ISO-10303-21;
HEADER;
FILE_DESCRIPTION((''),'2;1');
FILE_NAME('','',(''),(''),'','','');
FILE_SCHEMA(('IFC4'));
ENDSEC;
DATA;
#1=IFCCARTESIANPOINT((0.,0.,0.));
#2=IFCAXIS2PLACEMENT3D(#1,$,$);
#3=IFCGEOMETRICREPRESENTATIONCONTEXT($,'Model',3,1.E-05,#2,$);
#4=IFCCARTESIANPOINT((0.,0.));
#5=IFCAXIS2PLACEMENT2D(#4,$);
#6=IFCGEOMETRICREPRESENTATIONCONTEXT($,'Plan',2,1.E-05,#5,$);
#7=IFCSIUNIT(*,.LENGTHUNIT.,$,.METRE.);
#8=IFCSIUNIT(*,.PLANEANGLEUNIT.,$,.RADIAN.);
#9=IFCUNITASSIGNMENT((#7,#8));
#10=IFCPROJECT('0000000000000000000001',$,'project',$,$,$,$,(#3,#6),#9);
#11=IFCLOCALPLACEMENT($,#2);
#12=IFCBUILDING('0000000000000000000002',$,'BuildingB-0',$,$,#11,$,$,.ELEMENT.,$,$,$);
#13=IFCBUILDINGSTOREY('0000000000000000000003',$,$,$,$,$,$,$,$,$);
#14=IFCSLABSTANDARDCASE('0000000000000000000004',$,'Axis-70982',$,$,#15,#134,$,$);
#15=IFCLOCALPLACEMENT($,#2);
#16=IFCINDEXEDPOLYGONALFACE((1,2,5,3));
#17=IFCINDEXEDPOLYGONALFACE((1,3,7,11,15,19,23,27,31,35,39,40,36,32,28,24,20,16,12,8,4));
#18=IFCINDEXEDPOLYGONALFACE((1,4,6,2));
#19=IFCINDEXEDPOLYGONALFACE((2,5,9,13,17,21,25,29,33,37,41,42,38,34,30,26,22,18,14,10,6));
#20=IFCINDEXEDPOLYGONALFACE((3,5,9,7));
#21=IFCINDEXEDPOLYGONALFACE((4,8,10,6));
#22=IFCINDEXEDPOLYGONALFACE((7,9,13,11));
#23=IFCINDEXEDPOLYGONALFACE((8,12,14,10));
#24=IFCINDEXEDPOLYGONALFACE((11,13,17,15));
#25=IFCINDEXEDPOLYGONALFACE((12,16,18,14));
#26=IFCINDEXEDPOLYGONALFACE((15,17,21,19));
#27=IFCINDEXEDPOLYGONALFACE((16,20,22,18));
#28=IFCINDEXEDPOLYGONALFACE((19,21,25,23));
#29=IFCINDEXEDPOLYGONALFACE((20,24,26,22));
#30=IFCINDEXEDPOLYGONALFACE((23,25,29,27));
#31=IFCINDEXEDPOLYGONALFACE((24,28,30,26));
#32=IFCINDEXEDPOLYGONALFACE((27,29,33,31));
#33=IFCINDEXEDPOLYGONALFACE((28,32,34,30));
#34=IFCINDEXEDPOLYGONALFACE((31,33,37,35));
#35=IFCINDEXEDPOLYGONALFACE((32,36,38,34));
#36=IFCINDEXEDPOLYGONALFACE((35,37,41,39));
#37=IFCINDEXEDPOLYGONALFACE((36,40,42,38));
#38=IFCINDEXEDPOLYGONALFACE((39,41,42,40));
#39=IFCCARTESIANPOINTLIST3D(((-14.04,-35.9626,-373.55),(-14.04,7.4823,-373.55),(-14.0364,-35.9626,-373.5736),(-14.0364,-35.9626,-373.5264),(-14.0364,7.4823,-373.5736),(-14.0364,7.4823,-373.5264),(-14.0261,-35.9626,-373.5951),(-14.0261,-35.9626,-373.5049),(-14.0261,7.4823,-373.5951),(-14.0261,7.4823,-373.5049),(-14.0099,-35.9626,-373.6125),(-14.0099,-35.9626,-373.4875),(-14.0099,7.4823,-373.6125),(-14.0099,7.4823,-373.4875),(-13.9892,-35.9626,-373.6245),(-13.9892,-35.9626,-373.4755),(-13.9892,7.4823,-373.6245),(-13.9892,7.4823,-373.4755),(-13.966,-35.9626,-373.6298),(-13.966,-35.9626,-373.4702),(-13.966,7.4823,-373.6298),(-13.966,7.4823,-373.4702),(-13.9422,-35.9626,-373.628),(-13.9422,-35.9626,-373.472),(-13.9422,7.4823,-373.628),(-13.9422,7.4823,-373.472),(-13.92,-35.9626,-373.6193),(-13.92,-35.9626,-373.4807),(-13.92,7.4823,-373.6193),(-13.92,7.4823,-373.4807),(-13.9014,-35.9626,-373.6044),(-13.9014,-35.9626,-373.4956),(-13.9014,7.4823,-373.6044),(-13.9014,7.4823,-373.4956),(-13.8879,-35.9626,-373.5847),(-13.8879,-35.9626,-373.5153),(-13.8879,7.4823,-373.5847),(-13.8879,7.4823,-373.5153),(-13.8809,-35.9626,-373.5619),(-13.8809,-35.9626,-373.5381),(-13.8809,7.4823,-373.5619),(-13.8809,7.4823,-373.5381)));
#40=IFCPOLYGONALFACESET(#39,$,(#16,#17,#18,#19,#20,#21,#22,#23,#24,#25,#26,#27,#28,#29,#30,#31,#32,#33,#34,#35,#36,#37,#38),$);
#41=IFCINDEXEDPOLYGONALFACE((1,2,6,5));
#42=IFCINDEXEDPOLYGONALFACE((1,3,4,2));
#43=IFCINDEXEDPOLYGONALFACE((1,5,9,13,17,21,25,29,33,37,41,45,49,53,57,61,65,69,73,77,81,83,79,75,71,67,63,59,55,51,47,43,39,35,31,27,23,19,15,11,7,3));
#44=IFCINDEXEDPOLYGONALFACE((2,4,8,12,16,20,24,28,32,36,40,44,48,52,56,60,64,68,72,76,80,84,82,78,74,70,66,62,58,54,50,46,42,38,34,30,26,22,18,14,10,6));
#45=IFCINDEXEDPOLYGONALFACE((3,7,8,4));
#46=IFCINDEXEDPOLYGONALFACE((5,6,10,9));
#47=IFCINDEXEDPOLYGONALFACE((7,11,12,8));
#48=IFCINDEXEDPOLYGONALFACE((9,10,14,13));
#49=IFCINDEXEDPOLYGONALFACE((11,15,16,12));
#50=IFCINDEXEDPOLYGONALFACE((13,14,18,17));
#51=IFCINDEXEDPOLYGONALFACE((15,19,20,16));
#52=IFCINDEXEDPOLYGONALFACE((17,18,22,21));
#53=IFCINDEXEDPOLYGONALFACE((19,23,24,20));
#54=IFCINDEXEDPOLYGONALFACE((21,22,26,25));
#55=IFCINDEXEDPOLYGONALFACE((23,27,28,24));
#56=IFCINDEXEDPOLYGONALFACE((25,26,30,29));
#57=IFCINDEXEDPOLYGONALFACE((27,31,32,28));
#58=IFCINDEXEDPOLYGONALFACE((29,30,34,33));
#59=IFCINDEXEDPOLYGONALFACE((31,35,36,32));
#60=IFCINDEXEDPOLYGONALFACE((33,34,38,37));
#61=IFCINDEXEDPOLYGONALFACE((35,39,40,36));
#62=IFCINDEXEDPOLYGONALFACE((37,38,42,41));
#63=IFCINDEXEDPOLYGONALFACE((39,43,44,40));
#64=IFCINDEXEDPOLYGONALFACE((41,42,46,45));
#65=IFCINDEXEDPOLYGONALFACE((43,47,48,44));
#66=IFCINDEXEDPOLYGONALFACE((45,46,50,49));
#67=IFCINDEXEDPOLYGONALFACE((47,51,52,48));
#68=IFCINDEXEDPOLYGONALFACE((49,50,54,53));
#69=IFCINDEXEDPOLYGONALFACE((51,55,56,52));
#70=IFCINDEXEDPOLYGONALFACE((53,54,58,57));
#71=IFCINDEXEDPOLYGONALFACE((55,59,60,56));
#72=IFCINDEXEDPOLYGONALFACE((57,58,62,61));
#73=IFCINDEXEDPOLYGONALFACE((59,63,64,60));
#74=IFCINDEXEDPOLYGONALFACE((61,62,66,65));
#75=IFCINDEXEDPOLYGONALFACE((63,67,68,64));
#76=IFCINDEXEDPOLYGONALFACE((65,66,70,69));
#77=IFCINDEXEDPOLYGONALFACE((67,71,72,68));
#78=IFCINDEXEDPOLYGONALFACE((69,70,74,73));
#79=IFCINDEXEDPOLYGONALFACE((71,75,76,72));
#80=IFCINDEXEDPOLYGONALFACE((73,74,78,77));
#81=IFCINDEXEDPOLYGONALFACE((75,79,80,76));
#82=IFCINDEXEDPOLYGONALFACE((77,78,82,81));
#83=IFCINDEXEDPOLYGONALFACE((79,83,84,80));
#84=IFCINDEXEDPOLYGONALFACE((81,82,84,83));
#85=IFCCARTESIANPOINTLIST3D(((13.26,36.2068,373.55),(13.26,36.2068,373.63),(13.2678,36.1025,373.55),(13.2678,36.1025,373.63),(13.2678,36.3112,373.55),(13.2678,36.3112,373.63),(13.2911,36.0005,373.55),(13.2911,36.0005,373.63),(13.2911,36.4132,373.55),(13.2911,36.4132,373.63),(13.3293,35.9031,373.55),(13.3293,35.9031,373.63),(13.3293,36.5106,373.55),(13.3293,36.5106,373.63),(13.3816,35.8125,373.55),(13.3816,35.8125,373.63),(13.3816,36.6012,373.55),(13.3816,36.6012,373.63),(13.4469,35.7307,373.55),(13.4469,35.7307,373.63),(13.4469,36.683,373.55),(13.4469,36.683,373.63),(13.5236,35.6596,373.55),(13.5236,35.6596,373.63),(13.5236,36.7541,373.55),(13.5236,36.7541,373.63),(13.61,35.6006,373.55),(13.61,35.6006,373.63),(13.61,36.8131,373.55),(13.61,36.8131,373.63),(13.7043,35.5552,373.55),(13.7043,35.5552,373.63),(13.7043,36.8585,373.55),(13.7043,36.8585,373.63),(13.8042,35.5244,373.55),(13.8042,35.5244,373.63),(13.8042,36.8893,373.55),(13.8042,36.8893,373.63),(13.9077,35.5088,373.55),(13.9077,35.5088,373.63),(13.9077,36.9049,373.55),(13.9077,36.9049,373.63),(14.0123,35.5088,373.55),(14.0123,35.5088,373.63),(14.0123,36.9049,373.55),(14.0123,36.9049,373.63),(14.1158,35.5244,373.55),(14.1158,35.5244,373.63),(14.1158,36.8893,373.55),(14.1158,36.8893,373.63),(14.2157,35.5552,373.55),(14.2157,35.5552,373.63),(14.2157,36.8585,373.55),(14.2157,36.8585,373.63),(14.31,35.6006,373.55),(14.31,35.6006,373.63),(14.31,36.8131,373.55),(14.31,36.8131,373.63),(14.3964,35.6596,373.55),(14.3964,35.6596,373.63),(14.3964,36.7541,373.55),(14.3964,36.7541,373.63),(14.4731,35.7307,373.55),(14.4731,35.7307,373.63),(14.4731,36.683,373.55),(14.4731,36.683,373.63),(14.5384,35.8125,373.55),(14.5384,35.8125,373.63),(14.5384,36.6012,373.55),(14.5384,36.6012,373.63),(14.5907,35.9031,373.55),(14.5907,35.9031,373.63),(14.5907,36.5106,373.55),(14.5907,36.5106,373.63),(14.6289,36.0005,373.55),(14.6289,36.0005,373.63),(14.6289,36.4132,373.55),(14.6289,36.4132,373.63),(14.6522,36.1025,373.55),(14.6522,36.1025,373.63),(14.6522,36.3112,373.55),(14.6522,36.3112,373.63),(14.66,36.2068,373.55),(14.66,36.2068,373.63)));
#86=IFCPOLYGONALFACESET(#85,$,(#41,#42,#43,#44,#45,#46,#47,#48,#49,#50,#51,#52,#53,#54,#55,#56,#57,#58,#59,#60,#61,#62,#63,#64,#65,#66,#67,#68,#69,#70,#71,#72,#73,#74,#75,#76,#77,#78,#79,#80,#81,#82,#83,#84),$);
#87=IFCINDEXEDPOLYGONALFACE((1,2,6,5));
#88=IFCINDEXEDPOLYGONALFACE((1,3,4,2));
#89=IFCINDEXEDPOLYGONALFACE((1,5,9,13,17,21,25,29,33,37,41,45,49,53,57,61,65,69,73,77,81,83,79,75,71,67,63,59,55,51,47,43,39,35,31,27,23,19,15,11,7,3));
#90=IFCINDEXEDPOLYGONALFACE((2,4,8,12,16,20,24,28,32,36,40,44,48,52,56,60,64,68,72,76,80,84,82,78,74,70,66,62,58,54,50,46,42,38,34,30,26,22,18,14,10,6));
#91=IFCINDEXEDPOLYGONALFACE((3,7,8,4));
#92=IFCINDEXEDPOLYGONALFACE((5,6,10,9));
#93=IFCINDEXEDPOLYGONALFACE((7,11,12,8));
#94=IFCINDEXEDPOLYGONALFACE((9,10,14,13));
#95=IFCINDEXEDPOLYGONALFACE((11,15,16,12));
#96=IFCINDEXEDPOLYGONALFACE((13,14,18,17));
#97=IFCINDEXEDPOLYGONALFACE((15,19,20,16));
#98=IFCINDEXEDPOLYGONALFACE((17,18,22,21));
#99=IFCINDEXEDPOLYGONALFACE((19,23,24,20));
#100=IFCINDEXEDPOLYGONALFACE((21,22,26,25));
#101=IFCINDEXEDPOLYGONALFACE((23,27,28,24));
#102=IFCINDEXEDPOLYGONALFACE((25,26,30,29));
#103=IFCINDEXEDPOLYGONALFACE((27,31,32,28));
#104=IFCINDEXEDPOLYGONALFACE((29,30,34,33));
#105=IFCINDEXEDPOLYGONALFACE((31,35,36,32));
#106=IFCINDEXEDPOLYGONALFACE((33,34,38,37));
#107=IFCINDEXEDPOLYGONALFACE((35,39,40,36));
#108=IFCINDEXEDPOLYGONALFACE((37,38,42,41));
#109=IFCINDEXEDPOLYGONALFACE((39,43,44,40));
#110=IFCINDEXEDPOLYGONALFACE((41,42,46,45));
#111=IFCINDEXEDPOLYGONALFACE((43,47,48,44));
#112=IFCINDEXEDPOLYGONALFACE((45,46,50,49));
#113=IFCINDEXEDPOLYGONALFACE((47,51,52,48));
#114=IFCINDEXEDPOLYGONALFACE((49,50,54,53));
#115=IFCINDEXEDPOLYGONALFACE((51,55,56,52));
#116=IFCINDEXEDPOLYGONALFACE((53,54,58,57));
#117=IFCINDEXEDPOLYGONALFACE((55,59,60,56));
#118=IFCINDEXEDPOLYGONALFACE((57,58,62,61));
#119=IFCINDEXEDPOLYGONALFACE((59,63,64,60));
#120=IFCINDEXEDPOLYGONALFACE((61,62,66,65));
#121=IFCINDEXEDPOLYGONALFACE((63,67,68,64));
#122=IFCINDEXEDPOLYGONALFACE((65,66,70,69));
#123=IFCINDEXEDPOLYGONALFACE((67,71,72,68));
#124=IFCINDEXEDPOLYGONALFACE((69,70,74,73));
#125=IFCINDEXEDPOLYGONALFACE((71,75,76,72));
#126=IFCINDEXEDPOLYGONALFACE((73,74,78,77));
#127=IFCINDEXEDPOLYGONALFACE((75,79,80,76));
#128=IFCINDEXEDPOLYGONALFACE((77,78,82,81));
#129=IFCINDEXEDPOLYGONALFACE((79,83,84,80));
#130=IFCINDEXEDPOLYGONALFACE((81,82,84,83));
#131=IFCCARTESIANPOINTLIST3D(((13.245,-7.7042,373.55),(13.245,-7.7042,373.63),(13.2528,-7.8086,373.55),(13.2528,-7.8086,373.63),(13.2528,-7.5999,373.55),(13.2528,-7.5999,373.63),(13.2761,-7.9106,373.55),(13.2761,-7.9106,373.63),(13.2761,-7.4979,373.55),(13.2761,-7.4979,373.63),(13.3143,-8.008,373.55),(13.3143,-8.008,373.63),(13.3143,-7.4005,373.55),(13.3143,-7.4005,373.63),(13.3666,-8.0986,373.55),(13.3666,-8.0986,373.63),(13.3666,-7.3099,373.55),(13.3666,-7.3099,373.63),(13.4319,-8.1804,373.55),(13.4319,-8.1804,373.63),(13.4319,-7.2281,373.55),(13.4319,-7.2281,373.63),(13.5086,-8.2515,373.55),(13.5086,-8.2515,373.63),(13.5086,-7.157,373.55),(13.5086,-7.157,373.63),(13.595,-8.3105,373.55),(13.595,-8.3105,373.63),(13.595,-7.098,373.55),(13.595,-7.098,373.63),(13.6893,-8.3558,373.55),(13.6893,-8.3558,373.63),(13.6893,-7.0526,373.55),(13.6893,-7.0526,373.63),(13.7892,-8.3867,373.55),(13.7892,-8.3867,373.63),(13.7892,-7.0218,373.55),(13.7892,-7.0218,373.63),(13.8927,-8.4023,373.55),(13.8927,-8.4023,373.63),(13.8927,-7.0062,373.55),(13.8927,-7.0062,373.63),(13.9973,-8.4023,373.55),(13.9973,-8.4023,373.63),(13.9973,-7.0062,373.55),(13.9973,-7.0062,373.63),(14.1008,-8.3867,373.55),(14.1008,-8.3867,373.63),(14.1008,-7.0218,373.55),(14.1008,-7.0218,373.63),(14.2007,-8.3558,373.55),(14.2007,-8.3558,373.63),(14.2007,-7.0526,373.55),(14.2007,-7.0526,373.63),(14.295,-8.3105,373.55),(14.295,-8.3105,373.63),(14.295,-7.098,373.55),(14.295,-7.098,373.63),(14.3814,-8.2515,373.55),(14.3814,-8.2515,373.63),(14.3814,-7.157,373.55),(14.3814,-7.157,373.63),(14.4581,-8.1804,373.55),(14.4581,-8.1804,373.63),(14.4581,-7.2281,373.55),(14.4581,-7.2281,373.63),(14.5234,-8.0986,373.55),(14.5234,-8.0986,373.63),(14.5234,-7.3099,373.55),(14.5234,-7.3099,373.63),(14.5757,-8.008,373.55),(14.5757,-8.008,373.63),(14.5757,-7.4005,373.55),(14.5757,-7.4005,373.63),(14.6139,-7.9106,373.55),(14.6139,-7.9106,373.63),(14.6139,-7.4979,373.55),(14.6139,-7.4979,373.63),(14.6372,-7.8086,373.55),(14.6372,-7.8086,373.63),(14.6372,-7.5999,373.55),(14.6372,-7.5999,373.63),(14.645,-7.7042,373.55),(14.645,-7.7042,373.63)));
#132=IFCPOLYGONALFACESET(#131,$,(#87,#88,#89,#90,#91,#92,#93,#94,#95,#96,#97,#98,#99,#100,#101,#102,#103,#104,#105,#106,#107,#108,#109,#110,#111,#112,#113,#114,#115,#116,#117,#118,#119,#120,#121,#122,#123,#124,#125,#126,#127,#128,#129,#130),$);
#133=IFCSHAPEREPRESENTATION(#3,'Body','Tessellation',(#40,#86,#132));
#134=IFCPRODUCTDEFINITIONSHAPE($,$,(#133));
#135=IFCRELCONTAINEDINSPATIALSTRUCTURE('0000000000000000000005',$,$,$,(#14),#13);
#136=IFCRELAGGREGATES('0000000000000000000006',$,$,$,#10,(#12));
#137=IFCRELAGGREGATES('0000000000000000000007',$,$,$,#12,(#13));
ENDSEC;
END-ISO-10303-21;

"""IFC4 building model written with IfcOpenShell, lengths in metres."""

from ifc_helpers import new_model, entity, si_unit, frame, origin, origin_2d, place, context, project, spatial, circle, extrude, element, save


model = new_model("IFC4")

# Units and contexts
model_context = context("Model", 3, precision=1e-05, world=origin())
plan_context = context("Plan", 2, precision=1e-05, world=origin_2d())
ifc_project = project(units=[si_unit("LENGTHUNIT", "METRE"), si_unit("PLANEANGLEUNIT", "RADIAN")], contexts=[model_context, plan_context])

# Building, storey
building_placement = place(None, origin())
building = spatial("IfcBuilding", under=ifc_project, at=building_placement, Name="BuildingB-0", CompositionType="ELEMENT")
storey = spatial("IfcBuildingStorey", under=building)

# Slab
element("IfcSlabStandardCase", 1, inside=storey, Name="Axis-70982", context=model_context, shape_type="AdvancedSweptSolid", body=[
    entity("IfcSurfaceCurveSweptAreaSolid", entity("IfcCircleProfileDef", "AREA", None, None, 0.08), None, entity("IfcPolyline", [entity("IfcCartesianPoint", [13.96, 35.9626, 373.55]), entity("IfcCartesianPoint", [13.96, -7.4823, 373.55])]), None, None, entity("IfcPlane", entity("IfcAxis2Placement3D", entity("IfcCartesianPoint", [13.96, 35.9626, 373.55]), entity("IfcDirection", [0.0, 0.0, 1.0]), entity("IfcDirection", [1.0, 0.0, 0.0])))),
    extrude(circle(Radius=0.7), frame((13.96, 36.2068, 373.55)), (0.0, 0.0, 1.0), 0.08),
    extrude(circle(Radius=0.7), frame((13.945, -7.7042, 373.55)), (0.0, 0.0, 1.0), 0.08),
])

save(model, "model.ifc")
